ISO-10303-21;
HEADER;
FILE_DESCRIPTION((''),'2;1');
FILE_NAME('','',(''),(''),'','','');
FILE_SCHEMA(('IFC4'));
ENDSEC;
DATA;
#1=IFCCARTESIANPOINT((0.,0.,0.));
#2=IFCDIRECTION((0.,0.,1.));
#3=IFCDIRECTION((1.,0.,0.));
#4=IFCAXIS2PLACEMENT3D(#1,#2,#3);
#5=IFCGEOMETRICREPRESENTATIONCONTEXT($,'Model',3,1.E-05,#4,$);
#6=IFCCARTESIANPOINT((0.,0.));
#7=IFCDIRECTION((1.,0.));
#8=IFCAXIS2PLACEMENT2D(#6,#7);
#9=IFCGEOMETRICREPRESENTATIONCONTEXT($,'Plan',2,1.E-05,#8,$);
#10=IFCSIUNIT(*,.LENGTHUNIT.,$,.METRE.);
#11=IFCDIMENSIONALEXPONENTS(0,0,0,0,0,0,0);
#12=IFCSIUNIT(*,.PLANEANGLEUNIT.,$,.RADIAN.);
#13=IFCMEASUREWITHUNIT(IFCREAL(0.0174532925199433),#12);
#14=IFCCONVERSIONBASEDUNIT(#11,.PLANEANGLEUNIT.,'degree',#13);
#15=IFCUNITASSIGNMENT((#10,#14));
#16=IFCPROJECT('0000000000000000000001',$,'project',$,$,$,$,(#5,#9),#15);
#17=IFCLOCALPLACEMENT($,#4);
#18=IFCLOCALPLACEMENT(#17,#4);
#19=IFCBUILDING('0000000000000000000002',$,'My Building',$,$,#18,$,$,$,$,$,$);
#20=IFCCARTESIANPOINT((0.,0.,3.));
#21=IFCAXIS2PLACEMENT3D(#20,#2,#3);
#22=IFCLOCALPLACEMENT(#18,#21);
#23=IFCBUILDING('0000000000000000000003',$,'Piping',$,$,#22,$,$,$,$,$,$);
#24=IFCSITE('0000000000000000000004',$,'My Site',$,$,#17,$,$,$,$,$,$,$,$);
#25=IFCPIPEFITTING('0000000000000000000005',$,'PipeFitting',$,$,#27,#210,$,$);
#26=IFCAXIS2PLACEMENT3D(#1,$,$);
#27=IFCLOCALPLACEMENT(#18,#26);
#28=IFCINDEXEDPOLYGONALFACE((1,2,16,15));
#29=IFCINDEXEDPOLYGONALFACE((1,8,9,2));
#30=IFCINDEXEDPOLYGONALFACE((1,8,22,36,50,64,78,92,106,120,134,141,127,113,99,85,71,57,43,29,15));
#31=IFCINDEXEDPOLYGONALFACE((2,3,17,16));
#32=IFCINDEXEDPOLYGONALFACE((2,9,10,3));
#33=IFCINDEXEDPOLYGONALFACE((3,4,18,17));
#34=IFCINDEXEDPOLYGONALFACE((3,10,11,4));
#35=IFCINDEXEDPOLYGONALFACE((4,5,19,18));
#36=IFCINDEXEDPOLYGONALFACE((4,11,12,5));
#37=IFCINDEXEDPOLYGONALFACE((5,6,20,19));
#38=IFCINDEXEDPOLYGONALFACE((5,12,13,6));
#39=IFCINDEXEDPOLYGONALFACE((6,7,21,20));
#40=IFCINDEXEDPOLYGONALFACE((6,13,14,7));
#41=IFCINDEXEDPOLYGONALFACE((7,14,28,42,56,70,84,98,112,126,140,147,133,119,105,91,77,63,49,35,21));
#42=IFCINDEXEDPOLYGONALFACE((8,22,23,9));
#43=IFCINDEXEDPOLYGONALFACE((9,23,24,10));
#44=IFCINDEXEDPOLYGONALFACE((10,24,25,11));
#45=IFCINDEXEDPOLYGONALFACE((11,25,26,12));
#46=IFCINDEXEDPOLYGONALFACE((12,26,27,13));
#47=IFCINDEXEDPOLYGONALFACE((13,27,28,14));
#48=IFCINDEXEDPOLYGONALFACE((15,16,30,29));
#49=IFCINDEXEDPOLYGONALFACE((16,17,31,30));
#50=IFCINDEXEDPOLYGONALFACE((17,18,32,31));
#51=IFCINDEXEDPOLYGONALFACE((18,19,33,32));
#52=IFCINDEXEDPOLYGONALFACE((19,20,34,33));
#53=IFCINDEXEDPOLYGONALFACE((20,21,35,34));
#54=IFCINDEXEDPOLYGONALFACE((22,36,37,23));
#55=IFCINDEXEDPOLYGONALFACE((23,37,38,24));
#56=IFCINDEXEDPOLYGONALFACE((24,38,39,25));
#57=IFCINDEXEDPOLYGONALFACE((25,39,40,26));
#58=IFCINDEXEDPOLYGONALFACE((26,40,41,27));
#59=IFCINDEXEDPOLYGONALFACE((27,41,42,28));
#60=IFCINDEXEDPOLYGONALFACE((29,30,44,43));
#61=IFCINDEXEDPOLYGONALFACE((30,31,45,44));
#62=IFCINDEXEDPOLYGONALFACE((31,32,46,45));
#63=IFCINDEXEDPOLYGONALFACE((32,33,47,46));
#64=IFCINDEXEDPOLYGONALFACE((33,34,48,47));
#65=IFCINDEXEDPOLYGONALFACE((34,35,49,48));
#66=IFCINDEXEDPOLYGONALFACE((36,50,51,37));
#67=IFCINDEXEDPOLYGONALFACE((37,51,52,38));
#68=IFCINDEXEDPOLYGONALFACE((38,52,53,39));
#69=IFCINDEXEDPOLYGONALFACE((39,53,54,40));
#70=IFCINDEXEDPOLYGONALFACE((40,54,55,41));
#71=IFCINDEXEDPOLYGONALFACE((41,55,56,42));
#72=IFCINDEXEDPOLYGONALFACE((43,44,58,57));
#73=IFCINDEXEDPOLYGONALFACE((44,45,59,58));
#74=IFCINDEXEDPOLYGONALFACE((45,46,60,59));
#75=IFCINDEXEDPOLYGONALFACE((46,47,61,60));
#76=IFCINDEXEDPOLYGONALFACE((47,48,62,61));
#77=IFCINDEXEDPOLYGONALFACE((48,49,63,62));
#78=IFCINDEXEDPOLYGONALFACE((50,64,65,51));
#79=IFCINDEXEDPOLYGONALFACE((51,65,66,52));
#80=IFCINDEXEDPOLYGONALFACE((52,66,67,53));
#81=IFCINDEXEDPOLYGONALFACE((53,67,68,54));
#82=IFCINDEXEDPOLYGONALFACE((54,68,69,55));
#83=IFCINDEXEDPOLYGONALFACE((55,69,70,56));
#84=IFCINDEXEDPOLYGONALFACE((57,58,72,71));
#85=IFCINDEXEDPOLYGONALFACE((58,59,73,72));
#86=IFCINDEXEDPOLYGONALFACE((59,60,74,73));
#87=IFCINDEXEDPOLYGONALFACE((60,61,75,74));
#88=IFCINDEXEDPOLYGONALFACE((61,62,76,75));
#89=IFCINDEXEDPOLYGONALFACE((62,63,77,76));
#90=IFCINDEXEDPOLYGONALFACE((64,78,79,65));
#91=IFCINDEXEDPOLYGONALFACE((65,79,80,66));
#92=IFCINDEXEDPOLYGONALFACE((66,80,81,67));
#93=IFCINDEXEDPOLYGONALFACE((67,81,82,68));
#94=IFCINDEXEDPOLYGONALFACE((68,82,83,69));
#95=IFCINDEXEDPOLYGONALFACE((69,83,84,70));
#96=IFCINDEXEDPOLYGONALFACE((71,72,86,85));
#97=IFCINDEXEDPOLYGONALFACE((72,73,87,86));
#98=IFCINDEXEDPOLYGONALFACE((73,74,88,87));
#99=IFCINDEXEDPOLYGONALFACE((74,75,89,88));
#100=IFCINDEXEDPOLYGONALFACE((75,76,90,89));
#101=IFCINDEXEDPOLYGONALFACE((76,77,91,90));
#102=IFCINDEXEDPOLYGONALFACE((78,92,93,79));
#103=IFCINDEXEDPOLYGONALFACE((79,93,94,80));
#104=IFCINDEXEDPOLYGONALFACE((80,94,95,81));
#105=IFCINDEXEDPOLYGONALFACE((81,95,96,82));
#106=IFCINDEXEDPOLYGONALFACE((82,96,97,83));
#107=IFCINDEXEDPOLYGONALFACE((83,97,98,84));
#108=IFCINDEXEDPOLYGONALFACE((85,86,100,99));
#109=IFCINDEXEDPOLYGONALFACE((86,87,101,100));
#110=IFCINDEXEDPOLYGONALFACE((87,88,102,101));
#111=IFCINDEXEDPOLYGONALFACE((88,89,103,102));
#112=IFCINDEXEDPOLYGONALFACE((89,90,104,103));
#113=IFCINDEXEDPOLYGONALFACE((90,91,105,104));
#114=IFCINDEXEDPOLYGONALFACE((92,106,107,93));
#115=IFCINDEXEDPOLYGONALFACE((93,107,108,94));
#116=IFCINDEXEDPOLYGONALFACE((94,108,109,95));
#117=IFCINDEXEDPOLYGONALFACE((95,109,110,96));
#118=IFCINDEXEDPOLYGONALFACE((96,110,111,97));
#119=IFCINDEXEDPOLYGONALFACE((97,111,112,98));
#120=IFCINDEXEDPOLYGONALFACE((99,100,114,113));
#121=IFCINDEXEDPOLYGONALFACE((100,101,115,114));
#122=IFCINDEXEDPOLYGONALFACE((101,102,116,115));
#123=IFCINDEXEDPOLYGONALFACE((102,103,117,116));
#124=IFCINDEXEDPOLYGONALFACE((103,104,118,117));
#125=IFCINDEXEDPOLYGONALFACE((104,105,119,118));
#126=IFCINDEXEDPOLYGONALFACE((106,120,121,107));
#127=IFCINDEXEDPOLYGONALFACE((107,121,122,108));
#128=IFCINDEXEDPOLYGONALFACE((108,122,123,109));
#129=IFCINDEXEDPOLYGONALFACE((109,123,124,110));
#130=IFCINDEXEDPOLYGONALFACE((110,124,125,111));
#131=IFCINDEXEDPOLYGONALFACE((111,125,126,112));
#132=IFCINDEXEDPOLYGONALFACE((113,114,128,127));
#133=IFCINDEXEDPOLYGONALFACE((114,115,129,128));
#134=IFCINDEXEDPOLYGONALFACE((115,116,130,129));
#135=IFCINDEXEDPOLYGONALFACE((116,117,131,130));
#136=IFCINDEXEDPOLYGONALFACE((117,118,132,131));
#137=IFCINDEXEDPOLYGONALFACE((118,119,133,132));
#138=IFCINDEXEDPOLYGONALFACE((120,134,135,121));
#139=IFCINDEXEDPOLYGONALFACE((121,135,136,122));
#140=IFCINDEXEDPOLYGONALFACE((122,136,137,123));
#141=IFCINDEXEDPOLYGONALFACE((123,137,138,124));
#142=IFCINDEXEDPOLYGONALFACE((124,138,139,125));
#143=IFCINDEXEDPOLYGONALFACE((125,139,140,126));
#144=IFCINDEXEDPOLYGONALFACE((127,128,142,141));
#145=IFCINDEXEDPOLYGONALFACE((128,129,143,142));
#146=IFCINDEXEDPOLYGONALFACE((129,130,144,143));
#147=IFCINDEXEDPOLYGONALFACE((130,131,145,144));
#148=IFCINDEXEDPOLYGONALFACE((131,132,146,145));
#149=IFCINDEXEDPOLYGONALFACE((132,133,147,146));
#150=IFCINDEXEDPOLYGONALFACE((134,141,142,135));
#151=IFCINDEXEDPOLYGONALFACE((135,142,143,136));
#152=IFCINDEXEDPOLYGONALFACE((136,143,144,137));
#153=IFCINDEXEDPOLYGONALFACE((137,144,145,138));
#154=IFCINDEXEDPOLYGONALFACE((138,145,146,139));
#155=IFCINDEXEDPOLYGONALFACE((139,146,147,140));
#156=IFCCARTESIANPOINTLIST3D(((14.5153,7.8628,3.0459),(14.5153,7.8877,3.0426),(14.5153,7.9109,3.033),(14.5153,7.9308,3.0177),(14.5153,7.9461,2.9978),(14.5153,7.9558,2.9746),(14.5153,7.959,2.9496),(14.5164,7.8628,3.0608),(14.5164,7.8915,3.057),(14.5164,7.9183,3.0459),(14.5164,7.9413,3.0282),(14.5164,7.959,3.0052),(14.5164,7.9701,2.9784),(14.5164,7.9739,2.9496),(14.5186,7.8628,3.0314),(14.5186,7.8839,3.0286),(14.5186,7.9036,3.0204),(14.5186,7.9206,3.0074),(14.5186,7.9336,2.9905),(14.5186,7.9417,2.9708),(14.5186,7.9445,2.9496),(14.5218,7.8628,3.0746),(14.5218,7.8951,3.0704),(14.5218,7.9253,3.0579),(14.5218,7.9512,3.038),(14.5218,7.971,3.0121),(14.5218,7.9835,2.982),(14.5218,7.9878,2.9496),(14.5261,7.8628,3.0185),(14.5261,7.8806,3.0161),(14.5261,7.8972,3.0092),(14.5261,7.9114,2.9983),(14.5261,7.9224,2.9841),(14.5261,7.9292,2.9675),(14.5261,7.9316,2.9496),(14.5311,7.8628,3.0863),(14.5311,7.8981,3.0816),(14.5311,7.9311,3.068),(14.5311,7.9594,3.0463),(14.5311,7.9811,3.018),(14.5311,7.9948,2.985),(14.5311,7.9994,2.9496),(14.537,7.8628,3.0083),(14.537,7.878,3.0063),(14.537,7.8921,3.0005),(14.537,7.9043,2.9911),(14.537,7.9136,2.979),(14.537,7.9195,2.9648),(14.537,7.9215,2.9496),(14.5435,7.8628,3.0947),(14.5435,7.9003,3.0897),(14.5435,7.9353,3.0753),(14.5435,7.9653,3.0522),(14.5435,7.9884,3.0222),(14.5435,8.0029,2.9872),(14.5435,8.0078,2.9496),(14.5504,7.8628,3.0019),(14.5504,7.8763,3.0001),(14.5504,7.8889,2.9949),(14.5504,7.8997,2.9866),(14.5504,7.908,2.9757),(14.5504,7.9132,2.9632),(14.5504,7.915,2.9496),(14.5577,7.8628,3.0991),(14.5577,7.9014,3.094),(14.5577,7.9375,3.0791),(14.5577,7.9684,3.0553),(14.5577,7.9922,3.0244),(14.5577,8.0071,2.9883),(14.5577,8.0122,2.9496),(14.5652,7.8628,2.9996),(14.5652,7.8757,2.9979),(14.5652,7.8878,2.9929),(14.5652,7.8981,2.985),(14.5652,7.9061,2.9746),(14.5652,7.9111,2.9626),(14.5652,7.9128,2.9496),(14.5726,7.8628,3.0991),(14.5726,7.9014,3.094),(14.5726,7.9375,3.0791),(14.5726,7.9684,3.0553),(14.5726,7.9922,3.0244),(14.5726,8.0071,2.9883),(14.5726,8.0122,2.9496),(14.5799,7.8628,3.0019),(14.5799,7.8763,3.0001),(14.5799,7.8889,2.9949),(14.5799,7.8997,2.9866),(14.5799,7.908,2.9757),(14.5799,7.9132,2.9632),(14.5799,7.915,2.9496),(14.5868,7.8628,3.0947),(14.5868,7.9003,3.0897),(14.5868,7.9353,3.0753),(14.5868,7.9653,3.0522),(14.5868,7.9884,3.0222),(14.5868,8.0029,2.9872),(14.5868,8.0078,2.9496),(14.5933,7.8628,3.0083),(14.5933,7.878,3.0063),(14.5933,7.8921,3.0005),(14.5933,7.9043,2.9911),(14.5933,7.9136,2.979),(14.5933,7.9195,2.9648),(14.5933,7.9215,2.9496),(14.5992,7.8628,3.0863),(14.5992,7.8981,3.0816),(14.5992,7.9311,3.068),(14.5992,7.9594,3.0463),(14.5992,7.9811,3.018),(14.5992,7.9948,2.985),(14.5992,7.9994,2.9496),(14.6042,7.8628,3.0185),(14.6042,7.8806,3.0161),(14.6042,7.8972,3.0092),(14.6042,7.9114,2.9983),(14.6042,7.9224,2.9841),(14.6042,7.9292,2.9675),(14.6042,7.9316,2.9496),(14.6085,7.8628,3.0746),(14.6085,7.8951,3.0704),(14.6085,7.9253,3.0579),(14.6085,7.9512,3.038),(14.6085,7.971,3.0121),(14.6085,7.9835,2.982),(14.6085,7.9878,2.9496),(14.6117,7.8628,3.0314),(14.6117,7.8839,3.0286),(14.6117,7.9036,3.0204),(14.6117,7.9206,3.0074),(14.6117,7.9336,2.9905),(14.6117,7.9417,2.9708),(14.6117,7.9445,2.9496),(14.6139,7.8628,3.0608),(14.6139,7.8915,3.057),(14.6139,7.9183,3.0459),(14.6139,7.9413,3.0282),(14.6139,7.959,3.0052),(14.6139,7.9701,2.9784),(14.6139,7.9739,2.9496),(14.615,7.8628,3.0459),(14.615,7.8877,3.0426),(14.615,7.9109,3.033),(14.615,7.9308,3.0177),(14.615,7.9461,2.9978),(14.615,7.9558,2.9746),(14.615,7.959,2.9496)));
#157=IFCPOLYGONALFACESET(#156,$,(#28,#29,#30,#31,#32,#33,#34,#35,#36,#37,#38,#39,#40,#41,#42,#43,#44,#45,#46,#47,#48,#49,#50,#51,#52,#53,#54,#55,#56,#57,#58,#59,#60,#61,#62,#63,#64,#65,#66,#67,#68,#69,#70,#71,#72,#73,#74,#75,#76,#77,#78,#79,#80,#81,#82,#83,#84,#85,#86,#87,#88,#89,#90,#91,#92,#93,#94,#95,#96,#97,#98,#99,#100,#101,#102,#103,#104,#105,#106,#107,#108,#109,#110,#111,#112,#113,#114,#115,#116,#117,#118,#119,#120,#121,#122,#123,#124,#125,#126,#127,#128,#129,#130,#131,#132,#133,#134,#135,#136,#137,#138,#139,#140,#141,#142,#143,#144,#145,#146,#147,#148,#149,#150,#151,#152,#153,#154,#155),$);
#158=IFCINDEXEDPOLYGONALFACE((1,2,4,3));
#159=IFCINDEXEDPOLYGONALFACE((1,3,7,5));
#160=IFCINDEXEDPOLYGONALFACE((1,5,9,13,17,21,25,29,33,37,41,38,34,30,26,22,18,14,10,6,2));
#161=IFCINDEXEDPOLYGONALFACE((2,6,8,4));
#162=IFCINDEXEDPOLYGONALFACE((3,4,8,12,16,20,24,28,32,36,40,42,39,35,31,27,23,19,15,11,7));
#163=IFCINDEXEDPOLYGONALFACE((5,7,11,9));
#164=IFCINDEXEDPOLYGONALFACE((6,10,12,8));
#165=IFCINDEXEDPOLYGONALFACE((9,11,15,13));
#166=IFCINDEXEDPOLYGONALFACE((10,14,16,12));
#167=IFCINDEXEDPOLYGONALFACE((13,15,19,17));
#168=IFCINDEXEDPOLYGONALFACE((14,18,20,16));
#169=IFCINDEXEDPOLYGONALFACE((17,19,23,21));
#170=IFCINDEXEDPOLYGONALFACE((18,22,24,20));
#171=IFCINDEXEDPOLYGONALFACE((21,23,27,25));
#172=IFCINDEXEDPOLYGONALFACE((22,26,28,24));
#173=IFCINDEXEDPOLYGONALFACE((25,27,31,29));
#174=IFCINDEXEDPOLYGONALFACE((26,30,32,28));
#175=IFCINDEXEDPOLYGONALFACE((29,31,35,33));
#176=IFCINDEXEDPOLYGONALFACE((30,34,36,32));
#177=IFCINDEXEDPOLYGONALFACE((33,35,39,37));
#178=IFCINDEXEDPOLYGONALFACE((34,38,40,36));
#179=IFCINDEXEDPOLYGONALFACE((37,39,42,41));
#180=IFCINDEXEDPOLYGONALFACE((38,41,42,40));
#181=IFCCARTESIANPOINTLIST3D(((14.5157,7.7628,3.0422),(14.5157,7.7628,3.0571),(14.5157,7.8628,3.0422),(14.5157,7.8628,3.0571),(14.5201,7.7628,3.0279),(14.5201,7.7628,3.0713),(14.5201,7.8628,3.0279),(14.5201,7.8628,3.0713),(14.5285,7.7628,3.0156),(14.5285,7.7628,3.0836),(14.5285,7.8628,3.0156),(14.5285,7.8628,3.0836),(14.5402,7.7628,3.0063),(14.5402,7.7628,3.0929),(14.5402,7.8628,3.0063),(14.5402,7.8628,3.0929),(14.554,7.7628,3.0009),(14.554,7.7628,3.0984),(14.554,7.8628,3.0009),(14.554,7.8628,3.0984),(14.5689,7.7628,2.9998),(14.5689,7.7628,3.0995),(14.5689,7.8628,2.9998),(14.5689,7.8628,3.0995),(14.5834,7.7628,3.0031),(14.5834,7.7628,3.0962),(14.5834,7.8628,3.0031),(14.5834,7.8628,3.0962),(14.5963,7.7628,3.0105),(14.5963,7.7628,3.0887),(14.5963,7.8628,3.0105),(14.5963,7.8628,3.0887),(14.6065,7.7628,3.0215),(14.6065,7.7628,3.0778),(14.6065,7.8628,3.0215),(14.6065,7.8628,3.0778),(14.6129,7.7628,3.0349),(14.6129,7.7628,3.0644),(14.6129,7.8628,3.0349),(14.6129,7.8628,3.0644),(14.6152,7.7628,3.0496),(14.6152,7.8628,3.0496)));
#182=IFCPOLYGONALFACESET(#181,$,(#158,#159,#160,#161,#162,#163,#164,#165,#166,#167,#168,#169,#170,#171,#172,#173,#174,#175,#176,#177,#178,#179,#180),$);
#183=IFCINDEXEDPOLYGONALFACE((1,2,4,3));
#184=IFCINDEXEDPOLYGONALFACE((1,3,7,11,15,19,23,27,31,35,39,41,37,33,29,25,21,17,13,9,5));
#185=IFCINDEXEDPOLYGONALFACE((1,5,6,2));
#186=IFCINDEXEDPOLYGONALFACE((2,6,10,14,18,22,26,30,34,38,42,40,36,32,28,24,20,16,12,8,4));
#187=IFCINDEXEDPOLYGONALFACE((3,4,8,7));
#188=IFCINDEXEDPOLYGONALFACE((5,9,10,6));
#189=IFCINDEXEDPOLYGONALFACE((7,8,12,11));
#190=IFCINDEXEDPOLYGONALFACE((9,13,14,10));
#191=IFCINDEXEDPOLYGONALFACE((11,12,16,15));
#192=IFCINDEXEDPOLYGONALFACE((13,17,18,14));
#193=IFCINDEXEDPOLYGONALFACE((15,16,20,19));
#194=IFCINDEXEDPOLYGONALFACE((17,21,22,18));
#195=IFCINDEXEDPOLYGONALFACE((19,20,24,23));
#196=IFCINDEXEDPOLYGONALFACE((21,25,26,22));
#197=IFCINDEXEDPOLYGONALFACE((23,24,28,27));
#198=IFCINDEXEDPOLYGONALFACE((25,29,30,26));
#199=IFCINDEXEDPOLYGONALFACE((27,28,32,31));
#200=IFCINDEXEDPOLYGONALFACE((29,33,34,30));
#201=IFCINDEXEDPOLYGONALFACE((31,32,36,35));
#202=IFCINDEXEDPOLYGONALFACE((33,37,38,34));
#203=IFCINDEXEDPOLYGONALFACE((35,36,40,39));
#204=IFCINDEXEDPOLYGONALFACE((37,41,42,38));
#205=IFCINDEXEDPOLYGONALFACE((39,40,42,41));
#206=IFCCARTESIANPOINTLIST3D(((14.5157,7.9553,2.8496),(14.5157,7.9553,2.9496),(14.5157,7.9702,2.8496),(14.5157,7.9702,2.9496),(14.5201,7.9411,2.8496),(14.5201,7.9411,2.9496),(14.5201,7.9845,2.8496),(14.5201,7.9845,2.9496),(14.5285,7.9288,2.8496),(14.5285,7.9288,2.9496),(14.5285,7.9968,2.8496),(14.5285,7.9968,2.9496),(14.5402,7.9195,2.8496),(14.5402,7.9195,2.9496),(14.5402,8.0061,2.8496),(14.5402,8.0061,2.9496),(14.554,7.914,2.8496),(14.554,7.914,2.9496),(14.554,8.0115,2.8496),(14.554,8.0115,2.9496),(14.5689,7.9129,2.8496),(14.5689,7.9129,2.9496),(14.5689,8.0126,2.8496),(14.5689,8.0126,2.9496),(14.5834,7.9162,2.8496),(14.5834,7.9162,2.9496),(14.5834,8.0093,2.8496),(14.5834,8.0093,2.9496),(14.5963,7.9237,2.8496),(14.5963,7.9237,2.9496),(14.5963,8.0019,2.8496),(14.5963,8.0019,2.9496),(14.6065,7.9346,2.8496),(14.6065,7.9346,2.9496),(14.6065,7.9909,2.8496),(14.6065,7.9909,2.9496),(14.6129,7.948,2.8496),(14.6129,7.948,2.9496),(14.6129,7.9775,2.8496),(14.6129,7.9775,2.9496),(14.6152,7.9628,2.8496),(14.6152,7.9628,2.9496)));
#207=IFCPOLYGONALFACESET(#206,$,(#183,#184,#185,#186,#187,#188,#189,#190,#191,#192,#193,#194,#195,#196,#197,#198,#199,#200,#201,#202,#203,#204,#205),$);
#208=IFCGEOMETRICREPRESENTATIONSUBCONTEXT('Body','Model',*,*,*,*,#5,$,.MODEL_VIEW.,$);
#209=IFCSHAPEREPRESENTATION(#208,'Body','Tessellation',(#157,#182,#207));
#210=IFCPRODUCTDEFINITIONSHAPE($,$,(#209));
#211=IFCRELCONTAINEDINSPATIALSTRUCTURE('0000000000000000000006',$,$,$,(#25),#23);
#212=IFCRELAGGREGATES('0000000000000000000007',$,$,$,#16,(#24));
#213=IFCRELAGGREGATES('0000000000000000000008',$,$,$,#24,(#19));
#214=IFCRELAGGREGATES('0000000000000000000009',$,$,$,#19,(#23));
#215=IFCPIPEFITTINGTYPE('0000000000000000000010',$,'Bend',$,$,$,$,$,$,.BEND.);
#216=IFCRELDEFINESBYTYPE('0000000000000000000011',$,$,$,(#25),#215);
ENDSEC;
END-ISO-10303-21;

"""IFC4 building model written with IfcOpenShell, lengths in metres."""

from ifc_helpers import new_model, entity, si_unit, converted_unit, frame, origin_with_axes, origin_2d_with_axis, place, context, subcontext, project, spatial, circle, extrude, source, transform, mapped, type_object, type_shapes, element, save


model = new_model("IFC4")

# Units and contexts
model_context = context("Model", 3, precision=1e-05, world=origin_with_axes())
plan_context = context("Plan", 2, precision=1e-05, world=origin_2d_with_axis())
body_context = subcontext(model_context, "Body", "Model", "MODEL_VIEW")
ifc_project = project(units=[si_unit("LENGTHUNIT", "METRE"), converted_unit("PLANEANGLEUNIT", "degree", entity("IfcReal", 0.0174532925199433), si_unit("PLANEANGLEUNIT", "RADIAN"), dimensions=[0, 0, 0, 0, 0, 0, 0])], contexts=[model_context, plan_context])

# Site, buildings
site_placement = place(None, origin_with_axes())
site = spatial("IfcSite", under=ifc_project, at=site_placement, Name="My Site")
building_1_placement = place(site_placement, origin_with_axes())
building_1 = spatial("IfcBuilding", under=site, at=building_1_placement, Name="My Building")
building_2_placement = place(building_1_placement, frame((0.0, 0.0, 3.0), z_axis=(0.0, 0.0, 1.0), x_axis=(1.0, 0.0, 0.0)))
building_2 = spatial("IfcBuilding", under=building_1, at=building_2_placement, Name="Piping")

# Pipe fitting
pipe_fitting_type_1 = type_object("IfcPipeFittingType", Name="Bend", PredefinedType="BEND")
shared_shape = source(origin_with_axes(), body_context, "Body", "SolidModel", [
    entity("IfcSweptDiskSolid", entity("IfcIndexedPolyCurve", entity("IfcCartesianPointList3D", [[0.0, 0.0, 0.1], [0.0, 0.0293, 0.1707], [0.0, 0.1, 0.2]]), [entity("IfcArcIndex", [1, 2, 3])]), 0.05),
    extrude(circle(Radius=0.05), origin_with_axes(), (0.0, 0.0, 1.0), 0.1),
    extrude(circle(Radius=0.05), frame((0.0, 0.1, 0.2), z_axis=(0.0, 1.0, 0.0), x_axis=(1.0, 0.0, 0.0)), (0.0, 0.0, 1.0), 0.1),
])
type_shapes(pipe_fitting_type_1, [shared_shape])
for number, where, z_axis, x_axis, name in (
    (1, (14.5652, 7.7628, 0.0496), (0.0, 1.0, 0.0), (1.0, 0.0, 0.0), "PipeFitting"),
):
    element("IfcPipeFitting", number, at=place(building_2_placement, frame(where, z_axis=z_axis, x_axis=x_axis)), inside=building_2, type_object=pipe_fitting_type_1, Name=name, context=body_context, shape_type="MappedRepresentation", body=[
        mapped(shared_shape, transform((0.0, 0.0, 0.0), x_axis=(1.0, 0.0, 0.0), y_axis=(0.0, 1.0, 0.0), z_axis=(0.0, 0.0, 1.0), scale=1.0)),
    ])

save(model, "model.ifc")
